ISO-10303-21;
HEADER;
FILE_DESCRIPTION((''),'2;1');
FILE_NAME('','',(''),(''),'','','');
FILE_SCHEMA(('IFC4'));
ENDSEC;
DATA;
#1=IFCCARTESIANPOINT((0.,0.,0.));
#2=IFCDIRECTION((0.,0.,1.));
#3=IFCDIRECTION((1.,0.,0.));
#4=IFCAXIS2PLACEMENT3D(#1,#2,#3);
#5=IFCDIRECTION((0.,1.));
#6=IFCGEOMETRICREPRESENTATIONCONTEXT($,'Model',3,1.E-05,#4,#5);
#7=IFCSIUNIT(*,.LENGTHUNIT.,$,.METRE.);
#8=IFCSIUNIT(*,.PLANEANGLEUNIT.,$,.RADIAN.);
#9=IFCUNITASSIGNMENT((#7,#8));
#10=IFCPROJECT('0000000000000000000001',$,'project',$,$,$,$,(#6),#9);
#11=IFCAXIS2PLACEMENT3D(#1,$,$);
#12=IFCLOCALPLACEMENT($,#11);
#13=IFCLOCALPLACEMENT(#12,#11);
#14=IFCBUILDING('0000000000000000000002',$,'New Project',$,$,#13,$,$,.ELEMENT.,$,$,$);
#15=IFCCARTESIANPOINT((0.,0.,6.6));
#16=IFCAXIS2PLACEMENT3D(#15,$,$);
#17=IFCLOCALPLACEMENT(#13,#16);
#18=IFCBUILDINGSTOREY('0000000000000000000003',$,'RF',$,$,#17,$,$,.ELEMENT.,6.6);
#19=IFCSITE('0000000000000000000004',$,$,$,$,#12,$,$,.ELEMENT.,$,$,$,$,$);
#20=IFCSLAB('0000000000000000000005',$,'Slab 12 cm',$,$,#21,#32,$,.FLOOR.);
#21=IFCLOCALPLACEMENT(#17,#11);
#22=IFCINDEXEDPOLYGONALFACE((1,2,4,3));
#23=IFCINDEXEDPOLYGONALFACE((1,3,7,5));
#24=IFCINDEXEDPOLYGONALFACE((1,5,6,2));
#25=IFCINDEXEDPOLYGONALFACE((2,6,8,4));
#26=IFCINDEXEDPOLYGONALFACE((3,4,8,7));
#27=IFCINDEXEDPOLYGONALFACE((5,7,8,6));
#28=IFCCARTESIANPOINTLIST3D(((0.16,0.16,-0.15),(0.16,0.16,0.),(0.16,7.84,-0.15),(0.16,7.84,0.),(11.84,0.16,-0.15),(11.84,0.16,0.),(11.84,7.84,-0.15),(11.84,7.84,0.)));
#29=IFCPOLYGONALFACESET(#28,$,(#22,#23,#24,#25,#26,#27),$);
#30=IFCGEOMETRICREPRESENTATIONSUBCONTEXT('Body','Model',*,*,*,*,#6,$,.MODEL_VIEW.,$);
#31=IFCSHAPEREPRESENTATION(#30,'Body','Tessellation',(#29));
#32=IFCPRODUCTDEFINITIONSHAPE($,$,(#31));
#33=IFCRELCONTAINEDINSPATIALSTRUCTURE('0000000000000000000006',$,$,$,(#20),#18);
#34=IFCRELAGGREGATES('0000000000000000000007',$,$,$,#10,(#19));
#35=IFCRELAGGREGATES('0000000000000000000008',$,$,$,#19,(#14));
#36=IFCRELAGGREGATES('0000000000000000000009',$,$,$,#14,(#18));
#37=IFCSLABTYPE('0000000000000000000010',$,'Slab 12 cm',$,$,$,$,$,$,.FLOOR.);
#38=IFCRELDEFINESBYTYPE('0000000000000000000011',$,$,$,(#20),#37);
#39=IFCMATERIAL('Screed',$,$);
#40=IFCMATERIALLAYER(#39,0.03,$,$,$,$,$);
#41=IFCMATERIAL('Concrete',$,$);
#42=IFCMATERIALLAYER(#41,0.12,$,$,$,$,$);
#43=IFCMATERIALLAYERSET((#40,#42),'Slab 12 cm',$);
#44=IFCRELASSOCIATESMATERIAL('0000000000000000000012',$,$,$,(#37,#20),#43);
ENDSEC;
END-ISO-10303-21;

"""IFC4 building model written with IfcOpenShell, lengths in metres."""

from ifc_helpers import new_model, si_unit, direction, frame, origin, origin_with_axes, place, context, subcontext, project, spatial, polyline, outline, extrude, material, layer, layer_set, layer_usage, type_object, element, save


model = new_model("IFC4")

# Units and contexts
model_context = context("Model", 3, precision=1e-05, world=origin_with_axes(), true_north=direction((0.0, 1.0)))
body_context = subcontext(model_context, "Body", "Model", "MODEL_VIEW")
ifc_project = project(units=[si_unit("LENGTHUNIT", "METRE"), si_unit("PLANEANGLEUNIT", "RADIAN")], contexts=[model_context])

# Site, building, storey
site_placement = place(None, origin())
site = spatial("IfcSite", under=ifc_project, at=site_placement, CompositionType="ELEMENT")
building_placement = place(site_placement, origin())
building = spatial("IfcBuilding", under=site, at=building_placement, Name="New Project", CompositionType="ELEMENT")
storey_placement = place(building_placement, frame((0.0, 0.0, 6.6)))
storey = spatial("IfcBuildingStorey", under=building, at=storey_placement, Name="RF", CompositionType="ELEMENT", Elevation=6.6)

# Slab
ifc_material_1 = material(Name="Screed")
ifc_layer_1 = layer(ifc_material_1, 0.03)
ifc_material_2 = material(Name="Concrete")
ifc_layer_2 = layer(ifc_material_2, 0.12)
ifc_layer_set = layer_set([ifc_layer_1, ifc_layer_2], Name="Slab 12 cm")
ifc_layer_usage = layer_usage(ifc_layer_set, "AXIS3", "NEGATIVE", 0.15)
slab_type = type_object("IfcSlabType", Name="Slab 12 cm", PredefinedType="FLOOR", material=ifc_layer_set)
slab_placement = place(storey_placement, frame((0.0, 0.0, -0.15)))
element("IfcSlab", 1, at=slab_placement, inside=storey, type_object=slab_type, material=ifc_layer_usage, Name="Slab 12 cm", PredefinedType="FLOOR", context=body_context, shape_type="SweptSolid", body=[
    extrude(outline(polyline([(0.16, 0.16), (11.84, 0.16), (11.84, 7.84), (0.16, 7.84), (0.16, 0.16)])), origin(), (0.0, 0.0, 1.0), 0.15),
])

save(model, "model.ifc")
